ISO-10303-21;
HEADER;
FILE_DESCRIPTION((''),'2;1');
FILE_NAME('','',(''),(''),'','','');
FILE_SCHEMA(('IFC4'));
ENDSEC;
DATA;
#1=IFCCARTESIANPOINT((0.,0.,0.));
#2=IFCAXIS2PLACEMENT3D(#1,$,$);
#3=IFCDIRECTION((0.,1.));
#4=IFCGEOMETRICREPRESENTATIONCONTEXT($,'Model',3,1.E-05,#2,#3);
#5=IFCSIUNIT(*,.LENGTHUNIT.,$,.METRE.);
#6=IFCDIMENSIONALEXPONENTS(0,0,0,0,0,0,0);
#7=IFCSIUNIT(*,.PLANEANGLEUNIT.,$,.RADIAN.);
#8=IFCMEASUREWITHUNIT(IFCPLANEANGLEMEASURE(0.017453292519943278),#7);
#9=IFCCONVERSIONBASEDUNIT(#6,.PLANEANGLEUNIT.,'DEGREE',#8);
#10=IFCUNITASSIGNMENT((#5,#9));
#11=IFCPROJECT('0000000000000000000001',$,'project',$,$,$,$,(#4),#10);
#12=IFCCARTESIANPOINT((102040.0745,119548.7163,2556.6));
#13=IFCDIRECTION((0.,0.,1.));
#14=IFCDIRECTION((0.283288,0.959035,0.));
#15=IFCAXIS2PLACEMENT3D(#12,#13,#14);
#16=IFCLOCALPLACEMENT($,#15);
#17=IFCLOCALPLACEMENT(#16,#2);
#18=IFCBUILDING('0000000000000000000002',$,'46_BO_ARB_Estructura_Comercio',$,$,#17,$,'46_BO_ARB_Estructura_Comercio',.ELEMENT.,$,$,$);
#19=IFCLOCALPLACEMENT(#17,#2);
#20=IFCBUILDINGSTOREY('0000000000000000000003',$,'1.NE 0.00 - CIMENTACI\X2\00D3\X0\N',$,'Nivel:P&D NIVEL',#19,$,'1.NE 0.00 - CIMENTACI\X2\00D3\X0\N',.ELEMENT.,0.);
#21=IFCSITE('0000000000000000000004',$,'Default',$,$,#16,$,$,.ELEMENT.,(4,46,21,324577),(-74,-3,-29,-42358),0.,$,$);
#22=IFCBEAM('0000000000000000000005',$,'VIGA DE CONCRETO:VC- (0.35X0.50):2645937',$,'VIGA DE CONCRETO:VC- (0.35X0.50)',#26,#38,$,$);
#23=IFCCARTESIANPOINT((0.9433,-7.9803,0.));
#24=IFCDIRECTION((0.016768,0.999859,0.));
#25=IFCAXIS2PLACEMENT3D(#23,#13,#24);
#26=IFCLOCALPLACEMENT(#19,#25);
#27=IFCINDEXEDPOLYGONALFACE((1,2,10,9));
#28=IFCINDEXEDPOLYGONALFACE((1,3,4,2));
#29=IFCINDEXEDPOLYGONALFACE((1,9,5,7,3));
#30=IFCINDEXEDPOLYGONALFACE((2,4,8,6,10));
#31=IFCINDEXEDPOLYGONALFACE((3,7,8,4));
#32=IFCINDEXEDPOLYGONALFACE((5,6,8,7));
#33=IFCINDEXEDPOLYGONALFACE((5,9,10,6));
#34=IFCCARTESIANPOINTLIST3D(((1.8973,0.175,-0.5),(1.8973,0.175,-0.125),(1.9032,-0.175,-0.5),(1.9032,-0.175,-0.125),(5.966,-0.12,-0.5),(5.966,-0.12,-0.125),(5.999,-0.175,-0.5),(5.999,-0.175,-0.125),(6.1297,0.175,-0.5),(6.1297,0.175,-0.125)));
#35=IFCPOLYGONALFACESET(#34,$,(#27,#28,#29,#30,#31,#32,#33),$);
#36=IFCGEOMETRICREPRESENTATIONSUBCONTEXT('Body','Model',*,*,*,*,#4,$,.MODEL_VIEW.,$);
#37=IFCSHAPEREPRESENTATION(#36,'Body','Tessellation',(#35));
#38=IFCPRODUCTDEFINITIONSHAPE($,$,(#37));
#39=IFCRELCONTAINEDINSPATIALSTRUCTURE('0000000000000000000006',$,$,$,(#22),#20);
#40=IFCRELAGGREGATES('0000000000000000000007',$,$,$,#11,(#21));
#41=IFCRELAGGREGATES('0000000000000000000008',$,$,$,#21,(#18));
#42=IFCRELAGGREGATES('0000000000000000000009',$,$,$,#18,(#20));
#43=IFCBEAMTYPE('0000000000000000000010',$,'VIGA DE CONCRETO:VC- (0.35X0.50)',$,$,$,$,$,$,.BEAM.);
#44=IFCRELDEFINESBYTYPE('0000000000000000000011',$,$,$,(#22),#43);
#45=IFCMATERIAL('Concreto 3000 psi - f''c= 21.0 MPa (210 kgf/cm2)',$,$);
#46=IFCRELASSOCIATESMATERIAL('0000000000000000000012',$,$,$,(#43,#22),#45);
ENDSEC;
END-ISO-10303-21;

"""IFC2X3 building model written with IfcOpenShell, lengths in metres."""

from ifc_helpers import new_model, entity, si_unit, converted_unit, direction, frame, frame_2d, origin, place, context, subcontext, project, spatial, polyline, rectangle, extrude, clip, halfspace, bounded_halfspace, material, type_object, element, save


model = new_model("IFC2X3")

# Units and contexts
model_context = context("Model", 3, precision=1e-05, world=origin(), true_north=direction((0.0, 1.0)))
body_context = subcontext(model_context, "Body", "Model", "MODEL_VIEW")
ifc_project = project(units=[si_unit("LENGTHUNIT", "METRE"), converted_unit("PLANEANGLEUNIT", "DEGREE", entity("IfcPlaneAngleMeasure", 0.017453292519943278), si_unit("PLANEANGLEUNIT", "RADIAN"), dimensions=[0, 0, 0, 0, 0, 0, 0])], contexts=[model_context])

# Site, building, storey
site_placement = place(None, frame((102040.0745, 119548.7163, 2556.6), z_axis=(0.0, 0.0, 1.0), x_axis=(0.283288, 0.959035, 0.0)))
site = spatial("IfcSite", under=ifc_project, at=site_placement, Name="Default", CompositionType="ELEMENT", RefLatitude=(4, 46, 21, 324577), RefLongitude=(-74, -3, -29, -42358), RefElevation=0.0)
building_placement = place(site_placement, origin())
building = spatial("IfcBuilding", under=site, at=building_placement, Name="46_BO_ARB_Estructura_Comercio", LongName="46_BO_ARB_Estructura_Comercio", CompositionType="ELEMENT")
storey_placement = place(building_placement, origin())
storey = spatial("IfcBuildingStorey", under=building, at=storey_placement, Name="1.NE 0.00 - CIMENTACIÓN", ObjectType="Nivel:P&D NIVEL", LongName="1.NE 0.00 - CIMENTACIÓN", CompositionType="ELEMENT", Elevation=0.0)

# Beam
ifc_material_1 = material(Name="Concreto 3000 psi - f'c= 21.0 MPa (210 kgf/cm2)")
beam_type = type_object("IfcBeamType", Name="VIGA DE CONCRETO:VC- (0.35X0.50)", PredefinedType="BEAM", material=ifc_material_1)
beam_placement = place(storey_placement, frame((0.9433, -7.9803, 0.0), z_axis=(0.0, 0.0, 1.0), x_axis=(0.016768, 0.999859, 0.0)))
element("IfcBeam", 1, at=beam_placement, inside=storey, type_object=beam_type, material=ifc_material_1, Name="VIGA DE CONCRETO:VC- (0.35X0.50):2645937", ObjectType="VIGA DE CONCRETO:VC- (0.35X0.50)", context=body_context, shape_type="SweptSolid", body=[
    clip(clip(clip(extrude(rectangle(XDim=0.375, YDim=0.35, at=frame_2d((0.0, 0.0), x_axis=(1.0, 0.0))), frame((1.8973, 0.0, -0.3125), z_axis=(1.0, 0.0, 0.0), x_axis=(0.0, 0.0, -1.0)), (0.0, 0.0, 1.0), 4.2324), halfspace(frame((1.9101, -0.5881, 0.0), z_axis=(-0.999859, -0.016768, 0.0), x_axis=(0.0, 0.0, -1.0)), False)), bounded_halfspace(frame((5.966, -0.12, 0.0), z_axis=(0.857519, 0.514452, 0.0), x_axis=(0.0, 0.0, -1.0)), False, frame((1.8973, 0.0, -0.3125), z_axis=(1.0, 0.0, 0.0), x_axis=(0.0, 0.0, -1.0)), polyline([(0.1875, -0.175), (0.1875, -0.12), (-0.1875, -0.12), (-0.1875, -0.175), (0.1875, -0.175)]))), bounded_halfspace(frame((6.1902, 0.2838, 0.0), z_axis=(0.874288, -0.485407, 0.0), x_axis=(0.0, 0.0, -1.0)), False, frame((1.8973, 0.0, -0.3125), z_axis=(1.0, 0.0, 0.0), x_axis=(0.0, 0.0, -1.0)), polyline([(0.1875, -0.12), (0.1875, 0.175), (-0.1875, 0.175), (-0.1875, -0.12), (0.1875, -0.12)]))),
])

save(model, "model.ifc")
